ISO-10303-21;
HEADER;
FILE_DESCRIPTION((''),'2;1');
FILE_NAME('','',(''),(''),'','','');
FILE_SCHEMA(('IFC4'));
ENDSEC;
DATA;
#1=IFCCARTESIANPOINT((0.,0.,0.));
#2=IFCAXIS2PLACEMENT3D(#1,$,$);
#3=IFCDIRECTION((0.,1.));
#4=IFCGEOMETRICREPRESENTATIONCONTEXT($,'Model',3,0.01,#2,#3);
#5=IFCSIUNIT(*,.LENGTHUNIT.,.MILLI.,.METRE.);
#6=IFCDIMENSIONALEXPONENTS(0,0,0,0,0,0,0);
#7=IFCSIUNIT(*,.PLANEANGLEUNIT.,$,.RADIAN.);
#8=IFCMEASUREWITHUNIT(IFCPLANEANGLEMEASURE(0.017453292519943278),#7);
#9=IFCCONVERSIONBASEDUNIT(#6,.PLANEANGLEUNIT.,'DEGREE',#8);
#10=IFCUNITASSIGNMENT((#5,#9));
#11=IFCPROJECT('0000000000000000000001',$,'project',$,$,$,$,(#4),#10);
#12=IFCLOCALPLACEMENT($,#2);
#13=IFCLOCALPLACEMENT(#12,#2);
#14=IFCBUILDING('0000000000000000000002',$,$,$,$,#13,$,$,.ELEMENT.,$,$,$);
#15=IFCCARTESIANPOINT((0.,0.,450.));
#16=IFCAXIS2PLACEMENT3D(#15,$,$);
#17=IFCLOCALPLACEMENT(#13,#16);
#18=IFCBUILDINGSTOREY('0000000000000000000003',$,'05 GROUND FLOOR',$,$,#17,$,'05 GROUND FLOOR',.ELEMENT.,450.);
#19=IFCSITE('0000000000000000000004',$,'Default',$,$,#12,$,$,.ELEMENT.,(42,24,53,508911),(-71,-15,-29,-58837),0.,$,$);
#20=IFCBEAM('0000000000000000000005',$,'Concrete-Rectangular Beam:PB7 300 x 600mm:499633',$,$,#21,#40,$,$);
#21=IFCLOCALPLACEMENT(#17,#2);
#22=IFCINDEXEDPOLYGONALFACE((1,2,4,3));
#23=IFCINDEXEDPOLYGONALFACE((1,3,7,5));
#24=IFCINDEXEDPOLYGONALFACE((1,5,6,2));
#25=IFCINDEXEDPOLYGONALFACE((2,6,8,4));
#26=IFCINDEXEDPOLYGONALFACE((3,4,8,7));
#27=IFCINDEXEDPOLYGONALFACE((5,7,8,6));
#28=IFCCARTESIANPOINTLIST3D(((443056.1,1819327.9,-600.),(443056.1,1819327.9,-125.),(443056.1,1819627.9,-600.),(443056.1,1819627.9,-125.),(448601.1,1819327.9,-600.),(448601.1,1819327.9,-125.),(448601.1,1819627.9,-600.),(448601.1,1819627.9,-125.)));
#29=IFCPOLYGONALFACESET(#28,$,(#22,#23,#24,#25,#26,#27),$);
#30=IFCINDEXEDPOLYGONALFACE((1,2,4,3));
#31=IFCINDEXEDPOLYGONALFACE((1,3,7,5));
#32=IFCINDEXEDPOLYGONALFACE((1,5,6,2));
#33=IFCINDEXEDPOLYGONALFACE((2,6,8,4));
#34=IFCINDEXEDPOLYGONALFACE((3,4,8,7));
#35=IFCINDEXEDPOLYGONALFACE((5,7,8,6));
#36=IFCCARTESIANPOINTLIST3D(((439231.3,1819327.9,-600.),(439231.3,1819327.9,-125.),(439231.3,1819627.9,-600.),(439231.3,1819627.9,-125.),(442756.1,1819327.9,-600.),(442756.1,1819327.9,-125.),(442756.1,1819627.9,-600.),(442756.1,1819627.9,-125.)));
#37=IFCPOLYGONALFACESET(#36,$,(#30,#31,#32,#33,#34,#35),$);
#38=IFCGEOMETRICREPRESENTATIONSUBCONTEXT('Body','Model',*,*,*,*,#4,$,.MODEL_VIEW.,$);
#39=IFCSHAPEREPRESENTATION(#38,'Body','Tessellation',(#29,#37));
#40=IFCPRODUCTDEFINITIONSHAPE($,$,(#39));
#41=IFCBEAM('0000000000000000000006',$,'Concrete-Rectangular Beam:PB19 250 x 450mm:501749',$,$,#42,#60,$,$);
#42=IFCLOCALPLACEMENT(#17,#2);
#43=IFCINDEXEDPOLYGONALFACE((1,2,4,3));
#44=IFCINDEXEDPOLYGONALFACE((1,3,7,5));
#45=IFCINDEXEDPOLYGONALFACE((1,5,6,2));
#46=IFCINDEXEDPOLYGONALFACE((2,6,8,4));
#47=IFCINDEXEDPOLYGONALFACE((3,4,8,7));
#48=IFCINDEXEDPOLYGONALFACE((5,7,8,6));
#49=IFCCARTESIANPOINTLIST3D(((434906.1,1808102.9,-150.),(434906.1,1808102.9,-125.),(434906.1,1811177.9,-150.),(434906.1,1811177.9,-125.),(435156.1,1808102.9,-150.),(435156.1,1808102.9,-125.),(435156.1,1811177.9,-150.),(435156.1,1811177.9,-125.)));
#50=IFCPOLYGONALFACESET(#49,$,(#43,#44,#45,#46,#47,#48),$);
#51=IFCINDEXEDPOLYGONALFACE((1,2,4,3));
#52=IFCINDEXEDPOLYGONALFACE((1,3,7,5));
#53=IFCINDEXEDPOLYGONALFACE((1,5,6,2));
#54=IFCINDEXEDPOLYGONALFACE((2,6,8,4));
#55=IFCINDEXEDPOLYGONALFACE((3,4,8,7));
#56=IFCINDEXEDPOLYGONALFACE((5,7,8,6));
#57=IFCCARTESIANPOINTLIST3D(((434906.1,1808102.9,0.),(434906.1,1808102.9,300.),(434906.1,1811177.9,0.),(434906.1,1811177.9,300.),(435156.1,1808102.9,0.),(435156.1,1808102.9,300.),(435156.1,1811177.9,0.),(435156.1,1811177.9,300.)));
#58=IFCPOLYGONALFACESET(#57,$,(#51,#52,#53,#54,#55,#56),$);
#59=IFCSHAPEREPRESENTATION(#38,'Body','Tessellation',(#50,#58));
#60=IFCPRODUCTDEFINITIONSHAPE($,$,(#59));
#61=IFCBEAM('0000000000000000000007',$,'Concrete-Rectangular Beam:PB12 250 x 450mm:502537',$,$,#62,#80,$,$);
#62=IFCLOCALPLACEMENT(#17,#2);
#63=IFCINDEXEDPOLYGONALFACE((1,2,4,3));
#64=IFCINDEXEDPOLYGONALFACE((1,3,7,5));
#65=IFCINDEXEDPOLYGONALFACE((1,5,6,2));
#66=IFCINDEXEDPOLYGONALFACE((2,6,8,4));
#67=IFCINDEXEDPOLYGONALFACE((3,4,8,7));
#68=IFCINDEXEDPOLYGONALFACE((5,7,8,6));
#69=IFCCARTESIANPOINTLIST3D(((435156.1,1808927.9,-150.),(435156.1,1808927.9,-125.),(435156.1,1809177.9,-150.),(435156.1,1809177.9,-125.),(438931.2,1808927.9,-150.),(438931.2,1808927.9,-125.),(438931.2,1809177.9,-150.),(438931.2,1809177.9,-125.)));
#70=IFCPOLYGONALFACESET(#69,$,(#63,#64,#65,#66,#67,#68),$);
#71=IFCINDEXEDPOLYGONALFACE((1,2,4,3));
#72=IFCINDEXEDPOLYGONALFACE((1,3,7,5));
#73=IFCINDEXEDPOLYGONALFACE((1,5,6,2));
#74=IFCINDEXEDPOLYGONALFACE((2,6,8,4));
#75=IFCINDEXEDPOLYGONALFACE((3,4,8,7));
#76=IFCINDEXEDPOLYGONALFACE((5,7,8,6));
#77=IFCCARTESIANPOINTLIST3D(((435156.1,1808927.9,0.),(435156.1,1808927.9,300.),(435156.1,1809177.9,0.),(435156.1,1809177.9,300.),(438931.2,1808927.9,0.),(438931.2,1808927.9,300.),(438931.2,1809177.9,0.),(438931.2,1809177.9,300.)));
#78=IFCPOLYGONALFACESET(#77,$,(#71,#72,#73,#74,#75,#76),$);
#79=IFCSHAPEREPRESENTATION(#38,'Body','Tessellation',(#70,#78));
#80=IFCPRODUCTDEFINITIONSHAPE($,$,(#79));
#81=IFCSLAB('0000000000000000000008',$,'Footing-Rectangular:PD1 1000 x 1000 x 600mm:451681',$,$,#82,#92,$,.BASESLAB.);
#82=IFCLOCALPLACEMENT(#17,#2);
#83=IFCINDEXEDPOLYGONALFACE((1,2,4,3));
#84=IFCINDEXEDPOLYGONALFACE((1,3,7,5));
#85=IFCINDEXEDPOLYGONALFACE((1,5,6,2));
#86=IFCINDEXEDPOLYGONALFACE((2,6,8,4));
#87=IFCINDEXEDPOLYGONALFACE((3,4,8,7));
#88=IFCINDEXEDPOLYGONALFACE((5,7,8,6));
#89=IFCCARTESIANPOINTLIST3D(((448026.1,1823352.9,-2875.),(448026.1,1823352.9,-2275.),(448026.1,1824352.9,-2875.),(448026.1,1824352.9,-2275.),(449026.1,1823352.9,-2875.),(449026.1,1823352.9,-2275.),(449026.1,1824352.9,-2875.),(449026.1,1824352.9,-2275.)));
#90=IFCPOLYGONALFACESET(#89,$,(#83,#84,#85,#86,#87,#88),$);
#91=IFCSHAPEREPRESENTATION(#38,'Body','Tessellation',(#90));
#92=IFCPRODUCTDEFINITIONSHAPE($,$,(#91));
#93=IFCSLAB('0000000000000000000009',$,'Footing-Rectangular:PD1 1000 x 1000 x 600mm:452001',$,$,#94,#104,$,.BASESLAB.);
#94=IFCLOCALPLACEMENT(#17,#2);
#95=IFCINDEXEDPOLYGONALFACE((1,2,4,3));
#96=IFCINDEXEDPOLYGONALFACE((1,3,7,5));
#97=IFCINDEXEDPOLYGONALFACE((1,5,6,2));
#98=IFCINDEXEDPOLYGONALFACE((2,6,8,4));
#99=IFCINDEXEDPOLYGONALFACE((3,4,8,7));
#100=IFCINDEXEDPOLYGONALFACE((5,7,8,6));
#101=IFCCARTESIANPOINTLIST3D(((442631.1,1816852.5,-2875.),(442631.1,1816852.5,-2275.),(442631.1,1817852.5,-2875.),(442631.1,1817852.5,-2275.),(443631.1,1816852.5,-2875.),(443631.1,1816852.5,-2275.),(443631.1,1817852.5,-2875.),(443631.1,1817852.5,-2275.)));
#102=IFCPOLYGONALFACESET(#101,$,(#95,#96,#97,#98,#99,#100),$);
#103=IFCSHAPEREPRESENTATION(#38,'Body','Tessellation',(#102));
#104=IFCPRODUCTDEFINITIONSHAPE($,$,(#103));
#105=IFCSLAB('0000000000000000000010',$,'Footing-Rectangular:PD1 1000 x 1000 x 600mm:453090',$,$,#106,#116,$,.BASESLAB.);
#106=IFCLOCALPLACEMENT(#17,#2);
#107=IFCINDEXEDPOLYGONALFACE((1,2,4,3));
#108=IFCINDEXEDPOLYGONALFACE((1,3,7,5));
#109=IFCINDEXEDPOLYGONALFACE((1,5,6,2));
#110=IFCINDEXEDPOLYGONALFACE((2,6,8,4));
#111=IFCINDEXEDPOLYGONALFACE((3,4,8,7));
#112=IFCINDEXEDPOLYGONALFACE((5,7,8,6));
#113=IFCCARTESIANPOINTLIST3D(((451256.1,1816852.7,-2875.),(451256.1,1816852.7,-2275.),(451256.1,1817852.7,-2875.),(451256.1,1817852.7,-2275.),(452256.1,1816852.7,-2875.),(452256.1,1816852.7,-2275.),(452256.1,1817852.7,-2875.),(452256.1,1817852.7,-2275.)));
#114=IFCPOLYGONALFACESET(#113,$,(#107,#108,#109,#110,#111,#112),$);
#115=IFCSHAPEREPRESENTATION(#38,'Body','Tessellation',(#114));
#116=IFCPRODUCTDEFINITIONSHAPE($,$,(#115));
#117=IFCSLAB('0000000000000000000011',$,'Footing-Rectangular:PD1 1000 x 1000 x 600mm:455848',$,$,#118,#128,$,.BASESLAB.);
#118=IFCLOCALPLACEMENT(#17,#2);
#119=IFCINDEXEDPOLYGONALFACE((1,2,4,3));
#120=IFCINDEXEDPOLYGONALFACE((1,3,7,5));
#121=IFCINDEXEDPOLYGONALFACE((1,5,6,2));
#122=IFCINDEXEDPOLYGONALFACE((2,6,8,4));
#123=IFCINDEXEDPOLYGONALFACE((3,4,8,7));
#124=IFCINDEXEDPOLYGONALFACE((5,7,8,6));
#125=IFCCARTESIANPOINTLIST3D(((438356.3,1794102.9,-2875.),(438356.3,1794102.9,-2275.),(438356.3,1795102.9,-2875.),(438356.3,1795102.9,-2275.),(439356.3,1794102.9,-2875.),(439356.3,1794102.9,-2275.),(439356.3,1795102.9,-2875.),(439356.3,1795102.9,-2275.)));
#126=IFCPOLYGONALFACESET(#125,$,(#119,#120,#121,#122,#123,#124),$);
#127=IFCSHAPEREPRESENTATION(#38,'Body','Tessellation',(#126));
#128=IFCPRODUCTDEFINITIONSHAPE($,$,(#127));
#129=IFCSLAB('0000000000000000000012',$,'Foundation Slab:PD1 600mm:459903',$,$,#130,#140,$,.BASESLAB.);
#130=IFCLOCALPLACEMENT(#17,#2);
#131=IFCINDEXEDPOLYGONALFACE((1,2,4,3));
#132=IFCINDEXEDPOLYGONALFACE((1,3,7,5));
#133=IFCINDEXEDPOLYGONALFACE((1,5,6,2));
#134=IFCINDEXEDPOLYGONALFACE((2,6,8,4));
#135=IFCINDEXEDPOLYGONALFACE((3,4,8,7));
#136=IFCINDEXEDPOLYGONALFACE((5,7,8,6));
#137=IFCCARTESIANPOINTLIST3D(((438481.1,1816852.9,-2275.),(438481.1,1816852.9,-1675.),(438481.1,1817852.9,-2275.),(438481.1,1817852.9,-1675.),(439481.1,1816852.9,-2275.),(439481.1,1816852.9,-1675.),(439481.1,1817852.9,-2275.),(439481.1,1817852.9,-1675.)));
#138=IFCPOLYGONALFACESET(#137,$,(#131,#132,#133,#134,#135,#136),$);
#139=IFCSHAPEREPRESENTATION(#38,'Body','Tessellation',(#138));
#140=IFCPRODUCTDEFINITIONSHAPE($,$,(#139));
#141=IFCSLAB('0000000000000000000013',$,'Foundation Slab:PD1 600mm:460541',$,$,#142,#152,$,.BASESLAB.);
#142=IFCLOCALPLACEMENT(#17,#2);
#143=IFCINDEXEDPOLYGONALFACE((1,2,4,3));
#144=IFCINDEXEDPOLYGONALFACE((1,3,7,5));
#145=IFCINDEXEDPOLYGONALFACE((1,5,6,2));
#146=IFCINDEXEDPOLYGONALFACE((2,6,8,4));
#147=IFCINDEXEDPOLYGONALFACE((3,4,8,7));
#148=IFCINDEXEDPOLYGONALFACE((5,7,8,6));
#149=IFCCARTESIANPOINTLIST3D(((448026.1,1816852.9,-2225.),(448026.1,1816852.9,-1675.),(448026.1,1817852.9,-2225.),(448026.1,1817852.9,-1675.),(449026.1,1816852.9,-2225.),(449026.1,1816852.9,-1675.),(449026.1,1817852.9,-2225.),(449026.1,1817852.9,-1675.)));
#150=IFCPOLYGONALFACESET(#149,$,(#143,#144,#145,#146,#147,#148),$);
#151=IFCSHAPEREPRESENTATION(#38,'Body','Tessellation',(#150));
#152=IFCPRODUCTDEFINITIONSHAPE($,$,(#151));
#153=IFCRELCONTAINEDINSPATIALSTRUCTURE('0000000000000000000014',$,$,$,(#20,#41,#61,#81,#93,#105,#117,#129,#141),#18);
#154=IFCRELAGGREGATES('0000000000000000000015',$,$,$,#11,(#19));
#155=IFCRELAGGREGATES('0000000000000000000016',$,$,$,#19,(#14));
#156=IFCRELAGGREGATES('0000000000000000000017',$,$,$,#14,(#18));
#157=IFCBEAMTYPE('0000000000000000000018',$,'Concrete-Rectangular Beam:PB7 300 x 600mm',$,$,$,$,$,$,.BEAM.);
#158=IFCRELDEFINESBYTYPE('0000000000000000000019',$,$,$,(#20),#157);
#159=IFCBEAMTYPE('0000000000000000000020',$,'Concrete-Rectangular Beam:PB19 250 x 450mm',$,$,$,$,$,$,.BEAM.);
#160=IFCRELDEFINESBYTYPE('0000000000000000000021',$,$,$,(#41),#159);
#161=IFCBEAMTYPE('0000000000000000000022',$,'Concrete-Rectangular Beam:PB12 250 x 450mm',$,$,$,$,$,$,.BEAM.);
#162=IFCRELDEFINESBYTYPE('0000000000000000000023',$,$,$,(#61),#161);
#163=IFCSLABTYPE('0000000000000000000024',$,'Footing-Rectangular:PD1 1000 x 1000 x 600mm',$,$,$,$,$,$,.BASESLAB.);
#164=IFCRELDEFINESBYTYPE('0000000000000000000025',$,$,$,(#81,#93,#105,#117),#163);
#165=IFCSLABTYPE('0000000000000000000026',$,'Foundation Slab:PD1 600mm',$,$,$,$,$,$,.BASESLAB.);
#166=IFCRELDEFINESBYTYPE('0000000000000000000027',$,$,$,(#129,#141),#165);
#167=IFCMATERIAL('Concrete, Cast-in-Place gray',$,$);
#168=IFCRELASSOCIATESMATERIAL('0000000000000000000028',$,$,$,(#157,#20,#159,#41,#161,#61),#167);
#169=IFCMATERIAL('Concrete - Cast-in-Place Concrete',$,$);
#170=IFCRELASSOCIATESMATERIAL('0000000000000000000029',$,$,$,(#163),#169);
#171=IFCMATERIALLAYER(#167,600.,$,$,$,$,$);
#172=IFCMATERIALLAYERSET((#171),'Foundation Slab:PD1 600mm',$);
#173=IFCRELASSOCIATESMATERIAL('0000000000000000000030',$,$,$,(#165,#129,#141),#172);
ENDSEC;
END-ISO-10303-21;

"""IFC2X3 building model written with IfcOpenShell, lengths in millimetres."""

from ifc_helpers import new_model, entity, si_unit, converted_unit, direction, frame, frame_2d, origin, place, context, subcontext, project, spatial, rectangle, extrude, source, transform, mapped, material, layer, layer_set, layer_usage, type_object, type_shapes, element, save


model = new_model("IFC2X3")

# Units and contexts
model_context = context("Model", 3, precision=0.01, world=origin(), true_north=direction((0.0, 1.0)))
body_context = subcontext(model_context, "Body", "Model", "MODEL_VIEW")
ifc_project = project(units=[si_unit("LENGTHUNIT", "METRE", prefix="MILLI"), converted_unit("PLANEANGLEUNIT", "DEGREE", entity("IfcPlaneAngleMeasure", 0.017453292519943278), si_unit("PLANEANGLEUNIT", "RADIAN"), dimensions=[0, 0, 0, 0, 0, 0, 0])], contexts=[model_context])

# Site, building, storey
site_placement = place(None, origin())
site = spatial("IfcSite", under=ifc_project, at=site_placement, Name="Default", CompositionType="ELEMENT", RefLatitude=(42, 24, 53, 508911), RefLongitude=(-71, -15, -29, -58837), RefElevation=0.0)
building_placement = place(site_placement, origin())
building = spatial("IfcBuilding", under=site, at=building_placement, CompositionType="ELEMENT")
storey_placement = place(building_placement, frame((0.0, 0.0, 450.0)))
storey = spatial("IfcBuildingStorey", under=building, at=storey_placement, Name="05 GROUND FLOOR", LongName="05 GROUND FLOOR", CompositionType="ELEMENT", Elevation=450.0)

# Shared definitions
ifc_material_1 = material(Name="Concrete, Cast-in-Place gray")

# Beams
beam_type_1 = type_object("IfcBeamType", Name="Concrete-Rectangular Beam:PB7 300 x 600mm", PredefinedType="BEAM", material=ifc_material_1)
shared_shape_1 = source(origin(), body_context, "Body", "SweptSolid", [
    extrude(rectangle(XDim=475.0, YDim=300.0, at=frame_2d((0.0, 0.0), x_axis=(1.0, 0.0))), frame((443056.1, 1819477.9, 87.5), z_axis=(1.0, 0.0, 0.0), x_axis=(0.0, 0.0, -1.0)), (0.0, 0.0, 1.0), 5545.0),
    extrude(rectangle(XDim=475.0, YDim=300.0, at=frame_2d((0.0, 0.0), x_axis=(1.0, 0.0))), frame((439231.3, 1819477.9, 87.5), z_axis=(1.0, 0.0, 0.0), x_axis=(0.0, 0.0, -1.0)), (0.0, 0.0, 1.0), 3524.8),
])
type_shapes(beam_type_1, [shared_shape_1])
beam_1_placement = place(storey_placement, frame((0.0, 0.0, -450.0)))
element("IfcBeam", 1, at=beam_1_placement, inside=storey, type_object=beam_type_1, material=ifc_material_1, Name="Concrete-Rectangular Beam:PB7 300 x 600mm:499633", context=body_context, shape_type="MappedRepresentation", body=[
    mapped(shared_shape_1, transform((0.0, 0.0, 0.0), scale=1.0)),
])
beam_type_2 = type_object("IfcBeamType", Name="Concrete-Rectangular Beam:PB19 250 x 450mm", PredefinedType="BEAM", material=ifc_material_1)
shared_shape_2 = source(origin(), body_context, "Body", "SweptSolid", [
    extrude(rectangle(XDim=25.0, YDim=250.0, at=frame_2d((0.0, 0.0), x_axis=(0.0, 1.0))), frame((435031.1, 1811177.9, 312.5), z_axis=(0.0, -1.0, 0.0), x_axis=(-1.0, 0.0, 0.0)), (0.0, 0.0, 1.0), 3075.0),
    extrude(rectangle(XDim=300.0, YDim=250.0, at=frame_2d((0.0, 0.0), x_axis=(0.0, 1.0))), frame((435031.1, 1811177.9, 600.0), z_axis=(0.0, -1.0, 0.0), x_axis=(-1.0, 0.0, 0.0)), (0.0, 0.0, 1.0), 3075.0),
])
type_shapes(beam_type_2, [shared_shape_2])
beam_2_placement = place(storey_placement, frame((0.0, 0.0, -450.0)))
element("IfcBeam", 2, at=beam_2_placement, inside=storey, type_object=beam_type_2, material=ifc_material_1, Name="Concrete-Rectangular Beam:PB19 250 x 450mm:501749", context=body_context, shape_type="MappedRepresentation", body=[
    mapped(shared_shape_2, transform((0.0, 0.0, 0.0), scale=1.0)),
])
beam_type_3 = type_object("IfcBeamType", Name="Concrete-Rectangular Beam:PB12 250 x 450mm", PredefinedType="BEAM", material=ifc_material_1)
shared_shape_3 = source(origin(), body_context, "Body", "SweptSolid", [
    extrude(rectangle(XDim=25.0, YDim=250.0, at=frame_2d((0.0, 0.0), x_axis=(1.0, 0.0))), frame((435156.1, 1809052.9, 312.5), z_axis=(1.0, 0.0, 0.0), x_axis=(0.0, 0.0, -1.0)), (0.0, 0.0, 1.0), 3775.1),
    extrude(rectangle(XDim=300.0, YDim=250.0, at=frame_2d((0.0, 0.0), x_axis=(1.0, 0.0))), frame((435156.1, 1809052.9, 600.0), z_axis=(1.0, 0.0, 0.0), x_axis=(0.0, 0.0, -1.0)), (0.0, 0.0, 1.0), 3775.1),
])
type_shapes(beam_type_3, [shared_shape_3])
beam_3_placement = place(storey_placement, frame((0.0, 0.0, -450.0)))
element("IfcBeam", 3, at=beam_3_placement, inside=storey, type_object=beam_type_3, material=ifc_material_1, Name="Concrete-Rectangular Beam:PB12 250 x 450mm:502537", context=body_context, shape_type="MappedRepresentation", body=[
    mapped(shared_shape_3, transform((0.0, 0.0, 0.0), scale=1.0)),
])

# Slabs
ifc_material_2 = material(Name="Concrete - Cast-in-Place Concrete")
slab_type_1 = type_object("IfcSlabType", Name="Footing-Rectangular:PD1 1000 x 1000 x 600mm", PredefinedType="BASESLAB", material=ifc_material_2)
slab_1_placement = place(storey_placement, origin())
element("IfcSlab", 4, at=slab_1_placement, inside=storey, type_object=slab_type_1, Name="Footing-Rectangular:PD1 1000 x 1000 x 600mm:451681", PredefinedType="BASESLAB", context=body_context, shape_type="SweptSolid", body=[
    extrude(rectangle(XDim=1000.0, YDim=1000.0, at=frame_2d((0.0, 0.0), x_axis=(1.0, 0.0))), frame((448526.1, 1823852.9, -2875.0), z_axis=(0.0, 0.0, 1.0), x_axis=(-1.0, 0.0, 0.0)), (0.0, 0.0, 1.0), 600.0),
])
slab_2_placement = place(storey_placement, origin())
element("IfcSlab", 5, at=slab_2_placement, inside=storey, type_object=slab_type_1, Name="Footing-Rectangular:PD1 1000 x 1000 x 600mm:452001", PredefinedType="BASESLAB", context=body_context, shape_type="SweptSolid", body=[
    extrude(rectangle(XDim=1000.0, YDim=1000.0, at=frame_2d((0.0, 0.0), x_axis=(1.0, 0.0))), frame((443131.1, 1817352.5, -2875.0), z_axis=(0.0, 0.0, 1.0), x_axis=(-1.0, 0.0, 0.0)), (0.0, 0.0, 1.0), 600.0),
])
slab_3_placement = place(storey_placement, origin())
element("IfcSlab", 6, at=slab_3_placement, inside=storey, type_object=slab_type_1, Name="Footing-Rectangular:PD1 1000 x 1000 x 600mm:453090", PredefinedType="BASESLAB", context=body_context, shape_type="SweptSolid", body=[
    extrude(rectangle(XDim=1000.0, YDim=1000.0, at=frame_2d((0.0, 0.0), x_axis=(1.0, 0.0))), frame((451756.1, 1817352.7, -2875.0), z_axis=(0.0, 0.0, 1.0), x_axis=(-1.0, 0.0, 0.0)), (0.0, 0.0, 1.0), 600.0),
])
slab_4_placement = place(storey_placement, origin())
element("IfcSlab", 7, at=slab_4_placement, inside=storey, type_object=slab_type_1, Name="Footing-Rectangular:PD1 1000 x 1000 x 600mm:455848", PredefinedType="BASESLAB", context=body_context, shape_type="SweptSolid", body=[
    extrude(rectangle(XDim=1000.0, YDim=1000.0, at=frame_2d((0.0, 0.0), x_axis=(1.0, 0.0))), frame((438856.3, 1794602.9, -2875.0), z_axis=(0.0, 0.0, 1.0), x_axis=(-1.0, 0.0, 0.0)), (0.0, 0.0, 1.0), 600.0),
])
ifc_layer = layer(ifc_material_1, 600.0)
ifc_layer_set = layer_set([ifc_layer], Name="Foundation Slab:PD1 600mm")
ifc_layer_usage_1 = layer_usage(ifc_layer_set, "AXIS3", "POSITIVE", 0.0)
slab_type_2 = type_object("IfcSlabType", Name="Foundation Slab:PD1 600mm", PredefinedType="BASESLAB", material=ifc_layer_set)
slab_5_placement = place(storey_placement, origin())
element("IfcSlab", 8, at=slab_5_placement, inside=storey, type_object=slab_type_2, material=ifc_layer_usage_1, Name="Foundation Slab:PD1 600mm:459903", PredefinedType="BASESLAB", context=body_context, shape_type="SweptSolid", body=[
    extrude(rectangle(XDim=1000.0, YDim=1000.0, at=frame_2d((0.0, 0.0), x_axis=(1.0, 0.0))), frame((438981.1, 1817352.9, -1675.0), z_axis=(0.0, 0.0, -1.0), x_axis=(0.0, 1.0, 0.0)), (0.0, 0.0, 1.0), 600.0),
])
ifc_layer_usage_2 = layer_usage(ifc_layer_set, "AXIS3", "POSITIVE", 0.0)
slab_6_placement = place(storey_placement, origin())
element("IfcSlab", 9, at=slab_6_placement, inside=storey, type_object=slab_type_2, material=ifc_layer_usage_2, Name="Foundation Slab:PD1 600mm:460541", PredefinedType="BASESLAB", context=body_context, shape_type="SweptSolid", body=[
    extrude(rectangle(XDim=1000.0, YDim=1000.0, at=frame_2d((0.0, 0.0), x_axis=(1.0, 0.0))), frame((448526.1, 1817352.9, -1675.0), z_axis=(0.0, 0.0, -1.0), x_axis=(0.0, 1.0, 0.0)), (0.0, 0.0, 1.0), 550.0),
])

save(model, "model.ifc")
